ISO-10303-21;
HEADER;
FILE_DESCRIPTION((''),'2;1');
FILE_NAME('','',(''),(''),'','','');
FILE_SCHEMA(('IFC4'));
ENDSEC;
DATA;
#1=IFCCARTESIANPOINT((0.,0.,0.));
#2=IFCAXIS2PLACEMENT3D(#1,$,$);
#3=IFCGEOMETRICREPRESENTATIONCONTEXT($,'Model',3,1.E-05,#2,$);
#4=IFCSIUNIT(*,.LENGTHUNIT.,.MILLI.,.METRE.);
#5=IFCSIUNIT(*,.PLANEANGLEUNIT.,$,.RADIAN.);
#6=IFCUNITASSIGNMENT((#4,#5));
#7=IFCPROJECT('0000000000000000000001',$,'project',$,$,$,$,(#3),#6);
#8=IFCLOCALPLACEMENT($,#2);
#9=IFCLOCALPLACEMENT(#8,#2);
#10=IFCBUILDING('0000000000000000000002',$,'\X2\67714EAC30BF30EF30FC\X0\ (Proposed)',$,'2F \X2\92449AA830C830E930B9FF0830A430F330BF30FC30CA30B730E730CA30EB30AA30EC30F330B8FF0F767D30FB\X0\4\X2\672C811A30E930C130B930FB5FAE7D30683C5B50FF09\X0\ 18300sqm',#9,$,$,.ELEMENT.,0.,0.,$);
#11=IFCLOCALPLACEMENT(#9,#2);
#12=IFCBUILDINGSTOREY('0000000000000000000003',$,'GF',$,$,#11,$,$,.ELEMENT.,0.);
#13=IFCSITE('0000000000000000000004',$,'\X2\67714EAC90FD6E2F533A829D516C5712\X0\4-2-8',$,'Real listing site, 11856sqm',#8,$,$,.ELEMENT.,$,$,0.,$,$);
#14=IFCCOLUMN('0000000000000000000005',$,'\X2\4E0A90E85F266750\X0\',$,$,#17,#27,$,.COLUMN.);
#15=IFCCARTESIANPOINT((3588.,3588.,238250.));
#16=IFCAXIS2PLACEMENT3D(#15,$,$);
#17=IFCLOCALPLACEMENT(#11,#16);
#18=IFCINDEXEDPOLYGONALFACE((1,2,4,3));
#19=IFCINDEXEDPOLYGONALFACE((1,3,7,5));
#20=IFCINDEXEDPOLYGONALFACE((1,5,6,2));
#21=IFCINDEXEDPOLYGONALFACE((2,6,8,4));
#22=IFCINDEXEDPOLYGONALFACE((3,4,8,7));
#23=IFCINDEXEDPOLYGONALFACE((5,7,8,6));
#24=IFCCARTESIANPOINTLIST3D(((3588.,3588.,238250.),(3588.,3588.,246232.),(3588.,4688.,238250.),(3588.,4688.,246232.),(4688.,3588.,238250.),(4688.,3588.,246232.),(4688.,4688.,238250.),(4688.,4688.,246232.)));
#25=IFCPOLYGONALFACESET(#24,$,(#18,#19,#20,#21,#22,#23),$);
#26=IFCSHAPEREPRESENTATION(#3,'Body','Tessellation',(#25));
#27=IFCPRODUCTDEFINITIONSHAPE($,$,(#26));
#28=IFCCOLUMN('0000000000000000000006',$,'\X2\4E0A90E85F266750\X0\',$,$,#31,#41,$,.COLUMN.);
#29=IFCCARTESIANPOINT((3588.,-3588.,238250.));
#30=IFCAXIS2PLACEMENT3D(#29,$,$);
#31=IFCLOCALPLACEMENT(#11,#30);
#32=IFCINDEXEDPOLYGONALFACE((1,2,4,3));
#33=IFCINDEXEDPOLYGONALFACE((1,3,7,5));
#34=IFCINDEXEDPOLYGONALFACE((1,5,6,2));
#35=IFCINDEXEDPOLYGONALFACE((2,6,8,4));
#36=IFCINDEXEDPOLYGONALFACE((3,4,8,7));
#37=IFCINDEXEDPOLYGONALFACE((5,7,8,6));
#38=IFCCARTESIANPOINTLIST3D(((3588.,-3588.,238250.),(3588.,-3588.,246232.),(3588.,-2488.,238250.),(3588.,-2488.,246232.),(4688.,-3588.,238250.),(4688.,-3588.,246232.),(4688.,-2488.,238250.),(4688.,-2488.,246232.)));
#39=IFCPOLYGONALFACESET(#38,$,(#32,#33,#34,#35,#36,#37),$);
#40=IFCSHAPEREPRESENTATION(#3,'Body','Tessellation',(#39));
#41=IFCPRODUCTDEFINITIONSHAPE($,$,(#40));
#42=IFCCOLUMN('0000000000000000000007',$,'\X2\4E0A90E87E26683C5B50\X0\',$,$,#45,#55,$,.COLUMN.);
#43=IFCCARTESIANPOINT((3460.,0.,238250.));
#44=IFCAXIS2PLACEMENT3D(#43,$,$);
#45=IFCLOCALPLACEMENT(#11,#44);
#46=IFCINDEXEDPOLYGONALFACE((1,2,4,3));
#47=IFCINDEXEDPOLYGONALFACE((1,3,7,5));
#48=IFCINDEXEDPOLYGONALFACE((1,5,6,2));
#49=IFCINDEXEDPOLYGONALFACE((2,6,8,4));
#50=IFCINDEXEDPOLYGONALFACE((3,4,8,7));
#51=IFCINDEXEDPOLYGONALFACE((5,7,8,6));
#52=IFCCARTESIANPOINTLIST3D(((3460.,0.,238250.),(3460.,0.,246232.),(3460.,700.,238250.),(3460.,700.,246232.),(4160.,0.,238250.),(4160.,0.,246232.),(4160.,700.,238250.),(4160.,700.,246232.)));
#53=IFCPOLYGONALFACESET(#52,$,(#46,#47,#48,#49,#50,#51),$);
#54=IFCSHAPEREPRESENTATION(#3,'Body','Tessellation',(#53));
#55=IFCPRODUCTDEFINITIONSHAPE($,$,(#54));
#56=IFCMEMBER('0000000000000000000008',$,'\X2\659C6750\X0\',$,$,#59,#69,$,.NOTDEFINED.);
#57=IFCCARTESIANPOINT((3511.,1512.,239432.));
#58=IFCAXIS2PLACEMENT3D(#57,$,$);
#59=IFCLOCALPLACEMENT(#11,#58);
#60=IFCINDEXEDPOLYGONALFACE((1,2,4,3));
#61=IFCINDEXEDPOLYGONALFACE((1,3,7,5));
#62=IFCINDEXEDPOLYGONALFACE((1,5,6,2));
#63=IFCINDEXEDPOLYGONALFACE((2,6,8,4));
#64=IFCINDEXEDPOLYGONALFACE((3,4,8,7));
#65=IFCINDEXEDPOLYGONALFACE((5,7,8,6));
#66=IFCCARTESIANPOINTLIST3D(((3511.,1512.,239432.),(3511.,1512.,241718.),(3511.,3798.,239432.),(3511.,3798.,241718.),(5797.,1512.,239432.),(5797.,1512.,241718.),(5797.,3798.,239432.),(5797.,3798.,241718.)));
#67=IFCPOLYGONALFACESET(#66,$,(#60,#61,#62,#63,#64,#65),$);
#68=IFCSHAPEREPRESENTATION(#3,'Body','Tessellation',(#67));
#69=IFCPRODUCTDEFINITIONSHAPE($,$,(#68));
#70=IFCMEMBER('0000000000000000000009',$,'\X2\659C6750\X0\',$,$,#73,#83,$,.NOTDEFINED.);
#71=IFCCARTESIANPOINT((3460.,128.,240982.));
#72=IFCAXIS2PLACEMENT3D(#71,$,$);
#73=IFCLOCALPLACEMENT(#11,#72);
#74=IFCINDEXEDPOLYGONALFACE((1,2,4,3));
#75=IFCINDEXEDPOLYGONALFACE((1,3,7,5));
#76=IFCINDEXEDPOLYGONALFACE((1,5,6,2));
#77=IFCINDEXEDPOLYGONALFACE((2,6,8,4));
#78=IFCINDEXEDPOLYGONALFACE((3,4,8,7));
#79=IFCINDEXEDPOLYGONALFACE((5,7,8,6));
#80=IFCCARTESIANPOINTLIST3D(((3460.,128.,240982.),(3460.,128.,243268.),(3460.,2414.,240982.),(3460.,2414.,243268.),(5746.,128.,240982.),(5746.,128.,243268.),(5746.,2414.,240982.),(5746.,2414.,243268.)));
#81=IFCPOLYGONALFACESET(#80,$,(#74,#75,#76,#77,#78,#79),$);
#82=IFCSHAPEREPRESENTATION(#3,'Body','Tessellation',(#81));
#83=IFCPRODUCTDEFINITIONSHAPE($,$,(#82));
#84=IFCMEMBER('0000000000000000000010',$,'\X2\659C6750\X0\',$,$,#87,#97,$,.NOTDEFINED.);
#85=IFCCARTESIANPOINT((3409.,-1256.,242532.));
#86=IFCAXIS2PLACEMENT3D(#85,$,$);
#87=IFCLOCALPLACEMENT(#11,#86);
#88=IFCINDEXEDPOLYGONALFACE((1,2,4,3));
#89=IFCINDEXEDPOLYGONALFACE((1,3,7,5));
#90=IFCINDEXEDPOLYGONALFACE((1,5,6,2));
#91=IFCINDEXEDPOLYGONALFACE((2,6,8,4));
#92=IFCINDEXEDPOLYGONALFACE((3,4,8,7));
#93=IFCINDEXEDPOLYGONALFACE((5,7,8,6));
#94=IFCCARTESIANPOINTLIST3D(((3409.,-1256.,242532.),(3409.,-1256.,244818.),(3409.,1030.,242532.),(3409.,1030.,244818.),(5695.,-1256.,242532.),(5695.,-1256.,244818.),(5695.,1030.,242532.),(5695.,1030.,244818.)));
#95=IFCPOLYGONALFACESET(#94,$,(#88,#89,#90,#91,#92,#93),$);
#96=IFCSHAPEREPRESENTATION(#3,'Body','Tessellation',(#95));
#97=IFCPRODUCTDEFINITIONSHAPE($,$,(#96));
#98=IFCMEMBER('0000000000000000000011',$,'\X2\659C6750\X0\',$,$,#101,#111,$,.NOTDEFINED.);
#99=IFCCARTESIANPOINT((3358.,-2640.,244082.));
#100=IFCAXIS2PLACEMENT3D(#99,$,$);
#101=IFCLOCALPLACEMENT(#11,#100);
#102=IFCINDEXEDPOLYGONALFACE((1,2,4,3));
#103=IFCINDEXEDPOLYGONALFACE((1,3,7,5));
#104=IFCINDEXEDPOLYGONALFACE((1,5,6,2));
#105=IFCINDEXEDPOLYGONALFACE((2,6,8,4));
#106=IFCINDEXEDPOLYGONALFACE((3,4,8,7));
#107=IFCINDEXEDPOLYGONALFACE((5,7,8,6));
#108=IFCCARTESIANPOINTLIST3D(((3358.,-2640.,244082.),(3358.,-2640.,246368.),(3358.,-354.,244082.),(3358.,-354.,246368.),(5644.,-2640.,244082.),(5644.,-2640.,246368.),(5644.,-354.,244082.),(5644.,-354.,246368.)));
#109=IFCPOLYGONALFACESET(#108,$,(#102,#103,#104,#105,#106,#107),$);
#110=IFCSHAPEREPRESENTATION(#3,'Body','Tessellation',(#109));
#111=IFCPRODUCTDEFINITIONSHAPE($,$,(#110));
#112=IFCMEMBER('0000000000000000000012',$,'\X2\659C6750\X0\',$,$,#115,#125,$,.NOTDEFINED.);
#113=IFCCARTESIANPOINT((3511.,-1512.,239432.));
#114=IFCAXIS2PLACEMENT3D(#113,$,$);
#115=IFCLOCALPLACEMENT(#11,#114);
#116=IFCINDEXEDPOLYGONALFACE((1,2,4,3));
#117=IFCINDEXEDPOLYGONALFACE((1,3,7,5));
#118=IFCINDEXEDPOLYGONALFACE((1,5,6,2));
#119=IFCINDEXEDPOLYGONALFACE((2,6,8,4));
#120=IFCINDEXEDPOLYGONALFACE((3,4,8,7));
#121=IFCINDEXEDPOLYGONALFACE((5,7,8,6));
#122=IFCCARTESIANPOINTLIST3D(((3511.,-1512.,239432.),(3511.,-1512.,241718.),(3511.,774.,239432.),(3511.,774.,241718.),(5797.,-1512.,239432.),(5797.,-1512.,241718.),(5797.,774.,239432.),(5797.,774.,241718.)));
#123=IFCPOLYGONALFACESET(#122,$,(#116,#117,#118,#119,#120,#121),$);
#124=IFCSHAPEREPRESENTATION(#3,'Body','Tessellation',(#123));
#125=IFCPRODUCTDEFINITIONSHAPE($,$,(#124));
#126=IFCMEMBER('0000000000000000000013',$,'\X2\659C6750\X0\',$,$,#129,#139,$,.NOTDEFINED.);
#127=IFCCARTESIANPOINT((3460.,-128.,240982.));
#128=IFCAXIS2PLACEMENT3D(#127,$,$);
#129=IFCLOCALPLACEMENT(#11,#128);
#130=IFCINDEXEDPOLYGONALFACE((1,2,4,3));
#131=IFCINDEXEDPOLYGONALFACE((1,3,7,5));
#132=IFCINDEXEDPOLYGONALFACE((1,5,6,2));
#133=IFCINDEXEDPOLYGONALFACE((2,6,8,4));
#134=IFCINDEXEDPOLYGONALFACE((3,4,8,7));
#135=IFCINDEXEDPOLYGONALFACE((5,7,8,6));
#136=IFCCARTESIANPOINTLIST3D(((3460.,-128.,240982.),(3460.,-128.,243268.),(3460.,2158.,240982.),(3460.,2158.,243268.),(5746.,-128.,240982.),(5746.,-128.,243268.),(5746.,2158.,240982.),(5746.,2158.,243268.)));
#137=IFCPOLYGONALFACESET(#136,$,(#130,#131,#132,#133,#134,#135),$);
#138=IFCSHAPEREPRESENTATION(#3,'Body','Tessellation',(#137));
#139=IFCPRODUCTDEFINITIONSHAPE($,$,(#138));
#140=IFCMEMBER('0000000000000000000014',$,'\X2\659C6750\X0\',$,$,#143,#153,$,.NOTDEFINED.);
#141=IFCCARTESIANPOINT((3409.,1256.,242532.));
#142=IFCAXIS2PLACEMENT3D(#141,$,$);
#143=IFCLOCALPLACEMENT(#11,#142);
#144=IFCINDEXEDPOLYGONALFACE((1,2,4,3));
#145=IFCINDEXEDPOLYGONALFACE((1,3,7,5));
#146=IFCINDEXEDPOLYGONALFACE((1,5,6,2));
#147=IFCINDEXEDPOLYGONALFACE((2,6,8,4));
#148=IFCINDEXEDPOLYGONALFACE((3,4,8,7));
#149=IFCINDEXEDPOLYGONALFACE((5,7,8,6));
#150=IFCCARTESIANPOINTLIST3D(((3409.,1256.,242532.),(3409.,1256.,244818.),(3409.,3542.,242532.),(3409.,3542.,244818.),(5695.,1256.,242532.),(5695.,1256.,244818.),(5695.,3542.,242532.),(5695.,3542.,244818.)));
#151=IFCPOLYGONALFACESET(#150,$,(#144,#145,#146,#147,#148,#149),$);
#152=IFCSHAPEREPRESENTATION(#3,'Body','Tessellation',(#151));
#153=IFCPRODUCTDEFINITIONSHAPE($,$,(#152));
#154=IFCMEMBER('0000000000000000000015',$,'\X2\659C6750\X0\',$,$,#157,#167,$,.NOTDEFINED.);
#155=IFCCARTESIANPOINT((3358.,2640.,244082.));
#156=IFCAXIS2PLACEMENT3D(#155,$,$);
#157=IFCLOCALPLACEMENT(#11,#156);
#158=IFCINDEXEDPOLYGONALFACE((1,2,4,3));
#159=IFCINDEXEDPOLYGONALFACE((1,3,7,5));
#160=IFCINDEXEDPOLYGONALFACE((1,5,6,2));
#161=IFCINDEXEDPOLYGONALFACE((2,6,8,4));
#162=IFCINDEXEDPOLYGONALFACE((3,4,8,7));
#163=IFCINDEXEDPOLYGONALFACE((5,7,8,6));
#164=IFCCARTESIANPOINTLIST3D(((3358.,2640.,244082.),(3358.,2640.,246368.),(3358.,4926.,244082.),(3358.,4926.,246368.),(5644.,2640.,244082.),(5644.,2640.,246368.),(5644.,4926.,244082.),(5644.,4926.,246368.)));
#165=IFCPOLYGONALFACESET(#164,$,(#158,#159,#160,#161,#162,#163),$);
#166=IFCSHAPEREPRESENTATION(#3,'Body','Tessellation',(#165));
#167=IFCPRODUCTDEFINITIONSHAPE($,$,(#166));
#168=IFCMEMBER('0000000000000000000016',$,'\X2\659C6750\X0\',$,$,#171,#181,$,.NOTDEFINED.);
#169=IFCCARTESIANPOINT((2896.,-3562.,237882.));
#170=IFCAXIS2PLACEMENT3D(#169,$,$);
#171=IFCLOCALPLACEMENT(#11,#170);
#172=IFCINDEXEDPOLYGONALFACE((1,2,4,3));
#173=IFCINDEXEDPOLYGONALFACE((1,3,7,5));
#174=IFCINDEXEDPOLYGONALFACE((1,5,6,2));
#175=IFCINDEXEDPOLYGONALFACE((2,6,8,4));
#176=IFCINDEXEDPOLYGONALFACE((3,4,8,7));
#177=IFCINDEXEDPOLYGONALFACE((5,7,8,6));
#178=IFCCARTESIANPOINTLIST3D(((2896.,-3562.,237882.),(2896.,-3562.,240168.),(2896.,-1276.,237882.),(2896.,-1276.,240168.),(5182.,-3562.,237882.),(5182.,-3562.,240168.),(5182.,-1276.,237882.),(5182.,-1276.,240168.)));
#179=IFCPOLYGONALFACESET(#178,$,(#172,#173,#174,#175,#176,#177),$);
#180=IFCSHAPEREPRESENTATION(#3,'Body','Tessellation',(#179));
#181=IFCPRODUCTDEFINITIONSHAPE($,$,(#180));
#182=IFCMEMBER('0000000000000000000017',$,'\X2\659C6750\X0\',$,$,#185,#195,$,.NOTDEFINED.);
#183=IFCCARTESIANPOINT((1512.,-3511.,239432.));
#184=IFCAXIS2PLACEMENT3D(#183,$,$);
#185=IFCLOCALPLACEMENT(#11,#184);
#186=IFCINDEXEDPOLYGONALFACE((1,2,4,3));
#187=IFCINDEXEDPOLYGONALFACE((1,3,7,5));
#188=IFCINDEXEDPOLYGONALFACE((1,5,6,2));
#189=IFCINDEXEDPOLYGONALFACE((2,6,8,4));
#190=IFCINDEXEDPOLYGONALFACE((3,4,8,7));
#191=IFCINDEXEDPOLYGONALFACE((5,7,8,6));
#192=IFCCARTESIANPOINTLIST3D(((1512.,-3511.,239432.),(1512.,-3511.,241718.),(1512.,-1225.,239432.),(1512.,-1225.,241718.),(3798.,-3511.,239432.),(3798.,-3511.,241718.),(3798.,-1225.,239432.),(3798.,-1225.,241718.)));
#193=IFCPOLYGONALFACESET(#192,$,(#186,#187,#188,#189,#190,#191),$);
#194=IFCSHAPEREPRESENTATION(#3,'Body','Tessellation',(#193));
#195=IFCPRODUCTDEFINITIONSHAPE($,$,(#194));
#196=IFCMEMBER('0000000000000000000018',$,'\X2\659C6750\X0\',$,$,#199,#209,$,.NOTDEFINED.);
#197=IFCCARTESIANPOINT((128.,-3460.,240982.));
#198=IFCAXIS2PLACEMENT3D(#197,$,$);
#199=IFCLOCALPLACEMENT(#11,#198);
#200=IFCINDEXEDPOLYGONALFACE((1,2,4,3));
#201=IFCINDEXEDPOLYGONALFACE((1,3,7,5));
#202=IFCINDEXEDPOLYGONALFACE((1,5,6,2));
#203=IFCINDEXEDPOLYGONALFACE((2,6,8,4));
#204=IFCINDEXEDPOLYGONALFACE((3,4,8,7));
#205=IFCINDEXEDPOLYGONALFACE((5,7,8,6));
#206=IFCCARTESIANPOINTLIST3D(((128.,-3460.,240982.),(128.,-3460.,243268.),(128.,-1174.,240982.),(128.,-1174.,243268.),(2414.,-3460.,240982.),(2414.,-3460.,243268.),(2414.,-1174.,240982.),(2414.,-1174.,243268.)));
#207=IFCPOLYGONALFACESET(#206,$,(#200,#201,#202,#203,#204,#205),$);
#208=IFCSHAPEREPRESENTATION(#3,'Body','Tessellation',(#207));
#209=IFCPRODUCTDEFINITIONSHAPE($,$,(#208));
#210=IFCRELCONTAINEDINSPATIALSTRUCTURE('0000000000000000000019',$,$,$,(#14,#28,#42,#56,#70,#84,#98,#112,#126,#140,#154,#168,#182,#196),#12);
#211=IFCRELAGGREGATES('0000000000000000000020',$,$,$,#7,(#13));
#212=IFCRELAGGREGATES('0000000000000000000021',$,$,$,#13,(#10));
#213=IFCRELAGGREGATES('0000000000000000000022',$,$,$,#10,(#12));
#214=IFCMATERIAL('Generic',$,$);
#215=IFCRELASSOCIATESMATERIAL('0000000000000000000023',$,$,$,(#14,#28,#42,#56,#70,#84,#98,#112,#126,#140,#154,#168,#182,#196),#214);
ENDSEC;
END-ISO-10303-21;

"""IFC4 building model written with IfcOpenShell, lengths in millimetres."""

from ifc_helpers import new_model, si_unit, frame, frame_2d, origin, place, context, project, spatial, rectangle, extrude, material, element, save


model = new_model("IFC4")

# Units and contexts
model_context = context("Model", 3, precision=1e-05, world=origin())
ifc_project = project(units=[si_unit("LENGTHUNIT", "METRE", prefix="MILLI"), si_unit("PLANEANGLEUNIT", "RADIAN")], contexts=[model_context])

# Site, building, storey
site_placement = place(None, origin())
site = spatial("IfcSite", under=ifc_project, at=site_placement, Name="東京都港区芝公園4-2-8", ObjectType="Real listing site, 11856sqm", CompositionType="ELEMENT", RefElevation=0.0)
building_placement = place(site_placement, origin())
building = spatial("IfcBuilding", under=site, at=building_placement, Name="東京タワー (Proposed)", ObjectType="2F 鉄骨トラス（インターナショナルオレンジ／白・4本脚ラチス・微細格子） 18300sqm", CompositionType="ELEMENT", ElevationOfRefHeight=0.0, ElevationOfTerrain=0.0)
storey_placement = place(building_placement, origin())
storey = spatial("IfcBuildingStorey", under=building, at=storey_placement, Name="GF", CompositionType="ELEMENT", Elevation=0.0)

# Columns
ifc_material = material(Name="Generic")
column_1_placement = place(storey_placement, frame((3588.0, 3588.0, 238250.0)))
element("IfcColumn", 1, at=column_1_placement, inside=storey, material=ifc_material, Name="上部弦材", PredefinedType="COLUMN", context=model_context, shape_type="SweptSolid", body=[
    extrude(rectangle(XDim=1100.0, YDim=1100.0, at=frame_2d((550.0, 550.0))), frame((3588.0, 3588.0, 238250.0)), (0.0, 0.0, 1.0), 7982.0),
])
column_2_placement = place(storey_placement, frame((3588.0, -3588.0, 238250.0)))
element("IfcColumn", 2, at=column_2_placement, inside=storey, material=ifc_material, Name="上部弦材", PredefinedType="COLUMN", context=model_context, shape_type="SweptSolid", body=[
    extrude(rectangle(XDim=1100.0, YDim=1100.0, at=frame_2d((550.0, 550.0))), frame((3588.0, -3588.0, 238250.0)), (0.0, 0.0, 1.0), 7982.0),
])
column_3_placement = place(storey_placement, frame((3460.0, 0.0, 238250.0)))
element("IfcColumn", 3, at=column_3_placement, inside=storey, material=ifc_material, Name="上部縦格子", PredefinedType="COLUMN", context=model_context, shape_type="SweptSolid", body=[
    extrude(rectangle(XDim=700.0, YDim=700.0, at=frame_2d((350.0, 350.0))), frame((3460.0, 0.0, 238250.0)), (0.0, 0.0, 1.0), 7982.0),
])

# Members
member_1_placement = place(storey_placement, frame((3511.0, 1512.0, 239432.0)))
element("IfcMember", 4, at=member_1_placement, inside=storey, material=ifc_material, Name="斜材", PredefinedType="NOTDEFINED", context=model_context, shape_type="SweptSolid", body=[
    extrude(rectangle(XDim=2286.0, YDim=2286.0, at=frame_2d((1143.0, 1143.0))), frame((3511.0, 1512.0, 239432.0)), (0.0, 0.0, 1.0), 2286.0),
])
member_2_placement = place(storey_placement, frame((3460.0, 128.0, 240982.0)))
element("IfcMember", 5, at=member_2_placement, inside=storey, material=ifc_material, Name="斜材", PredefinedType="NOTDEFINED", context=model_context, shape_type="SweptSolid", body=[
    extrude(rectangle(XDim=2286.0, YDim=2286.0, at=frame_2d((1143.0, 1143.0))), frame((3460.0, 128.0, 240982.0)), (0.0, 0.0, 1.0), 2286.0),
])
member_3_placement = place(storey_placement, frame((3409.0, -1256.0, 242532.0)))
element("IfcMember", 6, at=member_3_placement, inside=storey, material=ifc_material, Name="斜材", PredefinedType="NOTDEFINED", context=model_context, shape_type="SweptSolid", body=[
    extrude(rectangle(XDim=2286.0, YDim=2286.0, at=frame_2d((1143.0, 1143.0))), frame((3409.0, -1256.0, 242532.0)), (0.0, 0.0, 1.0), 2286.0),
])
member_4_placement = place(storey_placement, frame((3358.0, -2640.0, 244082.0)))
element("IfcMember", 7, at=member_4_placement, inside=storey, material=ifc_material, Name="斜材", PredefinedType="NOTDEFINED", context=model_context, shape_type="SweptSolid", body=[
    extrude(rectangle(XDim=2286.0, YDim=2286.0, at=frame_2d((1143.0, 1143.0))), frame((3358.0, -2640.0, 244082.0)), (0.0, 0.0, 1.0), 2286.0),
])
member_5_placement = place(storey_placement, frame((3511.0, -1512.0, 239432.0)))
element("IfcMember", 8, at=member_5_placement, inside=storey, material=ifc_material, Name="斜材", PredefinedType="NOTDEFINED", context=model_context, shape_type="SweptSolid", body=[
    extrude(rectangle(XDim=2286.0, YDim=2286.0, at=frame_2d((1143.0, 1143.0))), frame((3511.0, -1512.0, 239432.0)), (0.0, 0.0, 1.0), 2286.0),
])
member_6_placement = place(storey_placement, frame((3460.0, -128.0, 240982.0)))
element("IfcMember", 9, at=member_6_placement, inside=storey, material=ifc_material, Name="斜材", PredefinedType="NOTDEFINED", context=model_context, shape_type="SweptSolid", body=[
    extrude(rectangle(XDim=2286.0, YDim=2286.0, at=frame_2d((1143.0, 1143.0))), frame((3460.0, -128.0, 240982.0)), (0.0, 0.0, 1.0), 2286.0),
])
member_7_placement = place(storey_placement, frame((3409.0, 1256.0, 242532.0)))
element("IfcMember", 10, at=member_7_placement, inside=storey, material=ifc_material, Name="斜材", PredefinedType="NOTDEFINED", context=model_context, shape_type="SweptSolid", body=[
    extrude(rectangle(XDim=2286.0, YDim=2286.0, at=frame_2d((1143.0, 1143.0))), frame((3409.0, 1256.0, 242532.0)), (0.0, 0.0, 1.0), 2286.0),
])
member_8_placement = place(storey_placement, frame((3358.0, 2640.0, 244082.0)))
element("IfcMember", 11, at=member_8_placement, inside=storey, material=ifc_material, Name="斜材", PredefinedType="NOTDEFINED", context=model_context, shape_type="SweptSolid", body=[
    extrude(rectangle(XDim=2286.0, YDim=2286.0, at=frame_2d((1143.0, 1143.0))), frame((3358.0, 2640.0, 244082.0)), (0.0, 0.0, 1.0), 2286.0),
])
member_9_placement = place(storey_placement, frame((2896.0, -3562.0, 237882.0)))
element("IfcMember", 12, at=member_9_placement, inside=storey, material=ifc_material, Name="斜材", PredefinedType="NOTDEFINED", context=model_context, shape_type="SweptSolid", body=[
    extrude(rectangle(XDim=2286.0, YDim=2286.0, at=frame_2d((1143.0, 1143.0))), frame((2896.0, -3562.0, 237882.0)), (0.0, 0.0, 1.0), 2286.0),
])
member_10_placement = place(storey_placement, frame((1512.0, -3511.0, 239432.0)))
element("IfcMember", 13, at=member_10_placement, inside=storey, material=ifc_material, Name="斜材", PredefinedType="NOTDEFINED", context=model_context, shape_type="SweptSolid", body=[
    extrude(rectangle(XDim=2286.0, YDim=2286.0, at=frame_2d((1143.0, 1143.0))), frame((1512.0, -3511.0, 239432.0)), (0.0, 0.0, 1.0), 2286.0),
])
member_11_placement = place(storey_placement, frame((128.0, -3460.0, 240982.0)))
element("IfcMember", 14, at=member_11_placement, inside=storey, material=ifc_material, Name="斜材", PredefinedType="NOTDEFINED", context=model_context, shape_type="SweptSolid", body=[
    extrude(rectangle(XDim=2286.0, YDim=2286.0, at=frame_2d((1143.0, 1143.0))), frame((128.0, -3460.0, 240982.0)), (0.0, 0.0, 1.0), 2286.0),
])

save(model, "model.ifc")
